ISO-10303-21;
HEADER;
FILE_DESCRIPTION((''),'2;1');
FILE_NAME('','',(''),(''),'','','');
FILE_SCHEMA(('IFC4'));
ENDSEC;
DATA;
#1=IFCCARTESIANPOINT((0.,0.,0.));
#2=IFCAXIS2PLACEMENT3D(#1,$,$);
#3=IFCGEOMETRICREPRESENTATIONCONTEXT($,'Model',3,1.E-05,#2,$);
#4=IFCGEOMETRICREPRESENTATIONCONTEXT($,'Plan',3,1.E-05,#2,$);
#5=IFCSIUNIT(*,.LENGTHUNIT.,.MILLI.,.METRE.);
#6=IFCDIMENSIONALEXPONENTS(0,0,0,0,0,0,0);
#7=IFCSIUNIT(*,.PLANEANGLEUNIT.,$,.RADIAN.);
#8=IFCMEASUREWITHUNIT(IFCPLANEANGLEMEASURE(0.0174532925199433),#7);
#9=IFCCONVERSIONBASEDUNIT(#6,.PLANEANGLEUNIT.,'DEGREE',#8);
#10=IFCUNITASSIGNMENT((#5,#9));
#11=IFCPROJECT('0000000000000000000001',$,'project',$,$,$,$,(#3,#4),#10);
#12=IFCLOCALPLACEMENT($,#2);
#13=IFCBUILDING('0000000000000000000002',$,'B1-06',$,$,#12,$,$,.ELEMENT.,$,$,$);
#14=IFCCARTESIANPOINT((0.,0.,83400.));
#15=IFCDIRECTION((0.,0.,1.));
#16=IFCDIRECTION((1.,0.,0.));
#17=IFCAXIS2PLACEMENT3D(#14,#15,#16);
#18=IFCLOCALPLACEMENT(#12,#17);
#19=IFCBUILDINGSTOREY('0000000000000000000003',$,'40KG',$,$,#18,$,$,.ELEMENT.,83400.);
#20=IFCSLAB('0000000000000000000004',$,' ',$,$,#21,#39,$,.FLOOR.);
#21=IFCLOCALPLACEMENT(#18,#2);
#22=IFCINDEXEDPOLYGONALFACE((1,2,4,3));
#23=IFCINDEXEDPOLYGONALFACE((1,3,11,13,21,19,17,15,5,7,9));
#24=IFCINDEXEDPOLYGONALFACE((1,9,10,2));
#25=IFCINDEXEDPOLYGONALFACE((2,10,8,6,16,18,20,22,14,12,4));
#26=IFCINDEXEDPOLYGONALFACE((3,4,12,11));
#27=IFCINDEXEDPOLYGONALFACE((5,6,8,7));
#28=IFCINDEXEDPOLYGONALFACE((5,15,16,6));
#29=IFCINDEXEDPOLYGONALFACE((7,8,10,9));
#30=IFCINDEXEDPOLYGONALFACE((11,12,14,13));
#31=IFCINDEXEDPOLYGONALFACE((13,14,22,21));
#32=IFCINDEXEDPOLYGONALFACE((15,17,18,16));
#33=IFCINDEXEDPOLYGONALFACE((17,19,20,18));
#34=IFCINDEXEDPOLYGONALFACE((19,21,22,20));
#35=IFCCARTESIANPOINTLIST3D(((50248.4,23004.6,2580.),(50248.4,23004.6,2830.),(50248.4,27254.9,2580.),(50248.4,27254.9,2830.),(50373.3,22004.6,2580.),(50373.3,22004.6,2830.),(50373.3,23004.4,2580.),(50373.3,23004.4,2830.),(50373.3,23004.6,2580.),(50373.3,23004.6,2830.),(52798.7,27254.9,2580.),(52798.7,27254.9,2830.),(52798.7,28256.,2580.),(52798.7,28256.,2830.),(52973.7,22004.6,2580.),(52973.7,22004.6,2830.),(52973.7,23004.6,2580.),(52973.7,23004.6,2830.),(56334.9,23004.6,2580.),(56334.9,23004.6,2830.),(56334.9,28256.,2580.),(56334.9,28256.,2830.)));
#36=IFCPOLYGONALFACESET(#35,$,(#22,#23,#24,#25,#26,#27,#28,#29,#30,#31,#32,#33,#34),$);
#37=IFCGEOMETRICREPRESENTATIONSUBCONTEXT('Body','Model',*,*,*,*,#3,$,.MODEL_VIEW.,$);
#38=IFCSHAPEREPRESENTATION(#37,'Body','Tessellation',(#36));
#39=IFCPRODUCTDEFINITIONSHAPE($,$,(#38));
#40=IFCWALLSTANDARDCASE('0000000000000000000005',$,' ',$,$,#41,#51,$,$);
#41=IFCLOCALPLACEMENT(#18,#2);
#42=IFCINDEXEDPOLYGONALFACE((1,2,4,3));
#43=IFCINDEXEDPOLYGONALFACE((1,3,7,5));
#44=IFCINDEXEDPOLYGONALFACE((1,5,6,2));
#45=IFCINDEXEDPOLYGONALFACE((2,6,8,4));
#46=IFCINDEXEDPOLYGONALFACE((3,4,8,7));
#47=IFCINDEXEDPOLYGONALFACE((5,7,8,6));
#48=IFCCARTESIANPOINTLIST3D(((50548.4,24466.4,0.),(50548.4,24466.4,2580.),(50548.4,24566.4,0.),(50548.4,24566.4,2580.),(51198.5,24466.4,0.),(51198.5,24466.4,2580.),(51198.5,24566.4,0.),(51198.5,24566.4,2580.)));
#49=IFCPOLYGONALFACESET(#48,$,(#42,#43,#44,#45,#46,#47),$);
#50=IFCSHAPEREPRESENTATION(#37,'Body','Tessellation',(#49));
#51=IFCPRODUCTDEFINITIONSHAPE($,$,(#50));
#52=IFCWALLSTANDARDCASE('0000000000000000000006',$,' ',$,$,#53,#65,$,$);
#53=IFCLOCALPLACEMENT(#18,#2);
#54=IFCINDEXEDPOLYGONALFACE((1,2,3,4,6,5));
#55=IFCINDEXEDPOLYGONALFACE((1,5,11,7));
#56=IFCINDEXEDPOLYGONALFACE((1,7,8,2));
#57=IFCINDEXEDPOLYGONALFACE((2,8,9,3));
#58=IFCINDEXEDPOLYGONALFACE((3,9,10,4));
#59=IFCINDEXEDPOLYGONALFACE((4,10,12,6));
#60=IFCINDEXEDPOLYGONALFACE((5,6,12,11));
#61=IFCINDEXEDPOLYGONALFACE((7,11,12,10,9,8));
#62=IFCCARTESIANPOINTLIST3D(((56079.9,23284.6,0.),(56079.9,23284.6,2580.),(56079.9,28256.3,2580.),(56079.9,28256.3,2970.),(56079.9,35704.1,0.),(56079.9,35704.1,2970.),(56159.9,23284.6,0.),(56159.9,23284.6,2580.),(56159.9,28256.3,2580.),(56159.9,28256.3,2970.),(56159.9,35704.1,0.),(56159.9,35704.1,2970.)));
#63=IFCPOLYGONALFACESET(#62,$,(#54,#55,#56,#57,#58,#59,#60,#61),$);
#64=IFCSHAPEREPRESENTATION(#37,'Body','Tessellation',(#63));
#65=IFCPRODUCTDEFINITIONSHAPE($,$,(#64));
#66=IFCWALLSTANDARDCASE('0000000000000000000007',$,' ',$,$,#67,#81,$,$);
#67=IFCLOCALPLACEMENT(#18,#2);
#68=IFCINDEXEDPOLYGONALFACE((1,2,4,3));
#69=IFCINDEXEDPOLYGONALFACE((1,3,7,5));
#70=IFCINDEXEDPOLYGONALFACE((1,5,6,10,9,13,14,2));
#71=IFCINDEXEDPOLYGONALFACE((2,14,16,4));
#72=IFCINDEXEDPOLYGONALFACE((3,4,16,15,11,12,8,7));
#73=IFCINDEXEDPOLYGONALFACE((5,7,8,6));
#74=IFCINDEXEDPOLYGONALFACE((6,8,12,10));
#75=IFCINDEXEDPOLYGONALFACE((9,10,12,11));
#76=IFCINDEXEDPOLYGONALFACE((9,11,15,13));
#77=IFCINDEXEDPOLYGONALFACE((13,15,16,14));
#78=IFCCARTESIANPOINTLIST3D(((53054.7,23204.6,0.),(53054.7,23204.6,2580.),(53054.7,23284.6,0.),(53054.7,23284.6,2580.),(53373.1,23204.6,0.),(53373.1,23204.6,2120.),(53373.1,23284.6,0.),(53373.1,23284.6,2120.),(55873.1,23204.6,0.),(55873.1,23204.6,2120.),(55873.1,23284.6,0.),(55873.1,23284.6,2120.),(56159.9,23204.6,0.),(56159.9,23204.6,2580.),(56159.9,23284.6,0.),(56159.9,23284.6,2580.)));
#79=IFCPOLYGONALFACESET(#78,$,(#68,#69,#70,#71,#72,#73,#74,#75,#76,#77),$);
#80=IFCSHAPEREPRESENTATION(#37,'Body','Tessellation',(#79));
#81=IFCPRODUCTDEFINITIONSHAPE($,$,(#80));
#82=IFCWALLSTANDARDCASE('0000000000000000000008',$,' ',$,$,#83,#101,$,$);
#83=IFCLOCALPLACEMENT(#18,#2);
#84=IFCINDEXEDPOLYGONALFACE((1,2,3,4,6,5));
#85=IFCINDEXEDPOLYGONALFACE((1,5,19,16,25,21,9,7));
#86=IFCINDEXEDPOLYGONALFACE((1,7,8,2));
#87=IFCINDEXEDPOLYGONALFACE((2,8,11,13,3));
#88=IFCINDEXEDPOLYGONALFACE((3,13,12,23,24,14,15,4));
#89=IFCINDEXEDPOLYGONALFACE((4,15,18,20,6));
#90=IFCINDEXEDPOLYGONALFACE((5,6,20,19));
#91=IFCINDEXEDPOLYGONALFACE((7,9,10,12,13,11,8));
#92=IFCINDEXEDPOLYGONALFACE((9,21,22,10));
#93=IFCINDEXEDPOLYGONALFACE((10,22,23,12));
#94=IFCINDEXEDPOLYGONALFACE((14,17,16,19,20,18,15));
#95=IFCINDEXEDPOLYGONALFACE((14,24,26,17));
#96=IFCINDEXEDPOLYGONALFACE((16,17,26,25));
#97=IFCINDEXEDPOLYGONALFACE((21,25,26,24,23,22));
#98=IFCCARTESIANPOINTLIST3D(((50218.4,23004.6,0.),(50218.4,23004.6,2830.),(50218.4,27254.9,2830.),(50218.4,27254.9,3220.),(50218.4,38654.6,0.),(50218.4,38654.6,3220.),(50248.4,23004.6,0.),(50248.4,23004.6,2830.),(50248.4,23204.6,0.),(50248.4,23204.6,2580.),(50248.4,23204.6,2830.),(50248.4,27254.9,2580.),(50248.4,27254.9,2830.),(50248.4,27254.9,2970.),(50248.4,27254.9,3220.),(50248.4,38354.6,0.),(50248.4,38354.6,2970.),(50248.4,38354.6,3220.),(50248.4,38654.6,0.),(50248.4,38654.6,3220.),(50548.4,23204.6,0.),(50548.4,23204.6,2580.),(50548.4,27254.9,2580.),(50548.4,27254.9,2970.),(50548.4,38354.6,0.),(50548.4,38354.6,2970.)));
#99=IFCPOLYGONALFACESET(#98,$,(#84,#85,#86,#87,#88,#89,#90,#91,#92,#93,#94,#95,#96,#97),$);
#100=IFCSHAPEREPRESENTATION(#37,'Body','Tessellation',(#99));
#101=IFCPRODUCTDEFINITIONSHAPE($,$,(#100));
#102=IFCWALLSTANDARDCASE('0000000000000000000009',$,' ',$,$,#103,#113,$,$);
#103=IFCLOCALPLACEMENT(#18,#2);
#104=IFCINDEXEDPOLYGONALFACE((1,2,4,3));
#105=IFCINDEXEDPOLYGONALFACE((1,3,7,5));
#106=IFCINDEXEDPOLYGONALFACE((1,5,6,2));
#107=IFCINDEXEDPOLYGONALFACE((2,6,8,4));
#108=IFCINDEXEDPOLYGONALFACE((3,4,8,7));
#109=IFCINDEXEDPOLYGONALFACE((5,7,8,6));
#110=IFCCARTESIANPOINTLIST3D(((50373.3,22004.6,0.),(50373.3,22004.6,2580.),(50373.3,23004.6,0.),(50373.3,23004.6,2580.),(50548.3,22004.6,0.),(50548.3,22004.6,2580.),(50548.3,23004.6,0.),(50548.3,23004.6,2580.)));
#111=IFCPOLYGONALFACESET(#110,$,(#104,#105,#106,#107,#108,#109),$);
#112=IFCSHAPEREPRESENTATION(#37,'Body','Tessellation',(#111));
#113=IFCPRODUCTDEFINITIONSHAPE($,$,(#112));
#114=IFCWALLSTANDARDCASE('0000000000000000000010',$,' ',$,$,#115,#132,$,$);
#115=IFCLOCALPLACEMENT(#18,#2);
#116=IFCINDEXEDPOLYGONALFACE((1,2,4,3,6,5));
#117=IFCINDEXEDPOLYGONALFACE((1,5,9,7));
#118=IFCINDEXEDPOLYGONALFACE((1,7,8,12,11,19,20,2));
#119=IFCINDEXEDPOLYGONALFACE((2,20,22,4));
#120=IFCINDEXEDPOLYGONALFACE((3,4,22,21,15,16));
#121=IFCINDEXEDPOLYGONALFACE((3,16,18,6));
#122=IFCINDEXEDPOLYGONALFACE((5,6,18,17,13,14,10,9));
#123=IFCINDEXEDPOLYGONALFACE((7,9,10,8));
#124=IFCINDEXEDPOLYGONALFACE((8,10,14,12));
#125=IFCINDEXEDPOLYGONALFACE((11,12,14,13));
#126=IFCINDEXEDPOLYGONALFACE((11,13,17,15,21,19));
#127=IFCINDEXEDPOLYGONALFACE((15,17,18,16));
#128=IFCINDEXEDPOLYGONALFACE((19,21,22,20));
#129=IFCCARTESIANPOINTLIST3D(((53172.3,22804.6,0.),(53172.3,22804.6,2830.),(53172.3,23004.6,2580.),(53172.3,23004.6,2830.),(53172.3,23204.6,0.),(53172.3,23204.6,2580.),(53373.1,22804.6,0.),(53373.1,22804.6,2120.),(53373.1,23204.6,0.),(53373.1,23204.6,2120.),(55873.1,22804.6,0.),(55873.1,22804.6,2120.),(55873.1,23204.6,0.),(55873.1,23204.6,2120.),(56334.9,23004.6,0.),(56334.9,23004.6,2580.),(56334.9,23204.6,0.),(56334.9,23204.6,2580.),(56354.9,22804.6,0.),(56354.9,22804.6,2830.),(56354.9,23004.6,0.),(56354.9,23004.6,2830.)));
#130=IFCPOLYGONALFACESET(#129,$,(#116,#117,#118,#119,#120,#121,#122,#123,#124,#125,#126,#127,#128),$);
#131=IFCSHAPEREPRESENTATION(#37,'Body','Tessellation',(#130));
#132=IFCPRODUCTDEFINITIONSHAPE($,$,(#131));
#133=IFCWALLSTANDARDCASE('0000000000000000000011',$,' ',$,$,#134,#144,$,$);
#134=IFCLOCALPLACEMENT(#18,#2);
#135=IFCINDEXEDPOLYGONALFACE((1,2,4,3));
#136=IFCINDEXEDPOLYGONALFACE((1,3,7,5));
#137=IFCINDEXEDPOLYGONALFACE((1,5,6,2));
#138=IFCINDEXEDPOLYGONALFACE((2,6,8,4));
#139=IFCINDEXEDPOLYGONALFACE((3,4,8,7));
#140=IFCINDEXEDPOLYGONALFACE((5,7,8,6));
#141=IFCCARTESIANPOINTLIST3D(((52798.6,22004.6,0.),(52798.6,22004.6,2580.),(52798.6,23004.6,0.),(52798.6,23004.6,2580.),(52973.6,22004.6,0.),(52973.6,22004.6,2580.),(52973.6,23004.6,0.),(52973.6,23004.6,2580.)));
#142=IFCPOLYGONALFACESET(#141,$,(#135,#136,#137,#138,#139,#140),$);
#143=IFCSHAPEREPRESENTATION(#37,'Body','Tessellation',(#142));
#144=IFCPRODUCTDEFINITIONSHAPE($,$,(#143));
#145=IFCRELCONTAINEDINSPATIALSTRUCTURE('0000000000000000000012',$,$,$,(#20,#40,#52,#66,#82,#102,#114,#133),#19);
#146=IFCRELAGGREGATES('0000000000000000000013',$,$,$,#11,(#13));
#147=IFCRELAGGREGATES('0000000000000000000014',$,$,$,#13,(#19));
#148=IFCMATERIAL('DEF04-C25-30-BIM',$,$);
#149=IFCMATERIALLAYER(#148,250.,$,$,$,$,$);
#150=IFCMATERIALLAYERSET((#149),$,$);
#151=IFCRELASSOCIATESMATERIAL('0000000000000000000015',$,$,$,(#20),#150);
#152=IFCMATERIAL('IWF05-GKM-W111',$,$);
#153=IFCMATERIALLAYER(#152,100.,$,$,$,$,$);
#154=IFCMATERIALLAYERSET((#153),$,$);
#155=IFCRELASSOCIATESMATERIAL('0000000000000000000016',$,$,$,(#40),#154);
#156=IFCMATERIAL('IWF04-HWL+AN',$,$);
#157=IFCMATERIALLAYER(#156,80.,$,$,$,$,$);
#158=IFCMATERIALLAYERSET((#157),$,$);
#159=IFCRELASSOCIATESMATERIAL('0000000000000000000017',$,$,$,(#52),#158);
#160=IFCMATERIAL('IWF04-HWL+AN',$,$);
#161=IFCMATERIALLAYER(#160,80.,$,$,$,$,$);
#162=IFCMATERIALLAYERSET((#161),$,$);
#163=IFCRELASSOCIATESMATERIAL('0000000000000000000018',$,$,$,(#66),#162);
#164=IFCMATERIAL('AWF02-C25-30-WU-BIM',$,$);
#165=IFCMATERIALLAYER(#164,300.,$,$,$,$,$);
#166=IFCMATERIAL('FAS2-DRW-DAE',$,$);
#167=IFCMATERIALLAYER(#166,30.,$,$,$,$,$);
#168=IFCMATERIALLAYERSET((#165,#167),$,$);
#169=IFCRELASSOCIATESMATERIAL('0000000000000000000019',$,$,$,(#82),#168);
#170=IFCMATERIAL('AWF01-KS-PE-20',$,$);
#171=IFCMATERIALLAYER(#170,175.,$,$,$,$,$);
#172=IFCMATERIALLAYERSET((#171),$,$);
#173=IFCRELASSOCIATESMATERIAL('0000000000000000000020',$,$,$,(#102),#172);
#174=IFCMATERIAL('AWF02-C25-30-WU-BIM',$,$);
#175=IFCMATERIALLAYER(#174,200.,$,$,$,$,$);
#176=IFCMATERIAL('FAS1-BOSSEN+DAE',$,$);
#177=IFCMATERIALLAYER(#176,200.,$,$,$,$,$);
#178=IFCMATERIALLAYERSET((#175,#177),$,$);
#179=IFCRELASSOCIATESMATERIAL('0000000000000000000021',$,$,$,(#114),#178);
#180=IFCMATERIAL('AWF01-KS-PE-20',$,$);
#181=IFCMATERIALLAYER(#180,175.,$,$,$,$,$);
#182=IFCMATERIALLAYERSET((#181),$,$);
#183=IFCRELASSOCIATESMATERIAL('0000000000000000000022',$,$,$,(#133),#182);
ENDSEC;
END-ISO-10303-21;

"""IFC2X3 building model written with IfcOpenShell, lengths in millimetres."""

from ifc_helpers import new_model, entity, si_unit, converted_unit, frame, frame_2d, origin, origin_with_axes, place, context, subcontext, project, spatial, polyline, rectangle, outline, extrude, clip, bounded_halfspace, material, layer, layer_set, layer_usage, element, save


model = new_model("IFC2X3")

# Units and contexts
model_context = context("Model", 3, precision=1e-05, world=origin())
plan_context = context("Plan", 3, precision=1e-05, world=origin())
body_context = subcontext(model_context, "Body", "Model", "MODEL_VIEW")
ifc_project = project(units=[si_unit("LENGTHUNIT", "METRE", prefix="MILLI"), converted_unit("PLANEANGLEUNIT", "DEGREE", entity("IfcPlaneAngleMeasure", 0.0174532925199433), si_unit("PLANEANGLEUNIT", "RADIAN"), dimensions=[0, 0, 0, 0, 0, 0, 0])], contexts=[model_context, plan_context])

# Building, storey
building_placement = place(None, origin())
building = spatial("IfcBuilding", under=ifc_project, at=building_placement, Name="B1-06", CompositionType="ELEMENT")
storey_placement = place(building_placement, frame((0.0, 0.0, 83400.0), z_axis=(0.0, 0.0, 1.0), x_axis=(1.0, 0.0, 0.0)))
storey = spatial("IfcBuildingStorey", under=building, at=storey_placement, Name="40KG", CompositionType="ELEMENT", Elevation=83400.0)

# Slab
ifc_material_1 = material(Name="DEF04-C25-30-BIM")
ifc_layer_1 = layer(ifc_material_1, 250.0)
ifc_layer_set_1 = layer_set([ifc_layer_1])
ifc_layer_usage_1 = layer_usage(ifc_layer_set_1, "AXIS3", "POSITIVE", 0.0)
slab_placement = place(storey_placement, frame((50248.4, 22004.6, 2580.0), z_axis=(0.0, 0.0, 1.0), x_axis=(1.0, 0.0, 0.0)))
element("IfcSlab", 1, at=slab_placement, inside=storey, material=ifc_layer_usage_1, Name=" ", PredefinedType="FLOOR", context=body_context, shape_type="SweptSolid", body=[
    extrude(outline(polyline([(2725.3, 0.0), (2725.3, 1000.0), (6086.5, 1000.0), (6086.5, 6251.4), (2550.3, 6251.4), (2550.3, 5250.3), (0.0, 5250.3), (0.0, 1000.0), (125.0, 1000.0), (125.0, 999.8), (124.9, 999.8), (124.9, 0.0), (2725.3, 0.0)])), origin_with_axes(), (0.0, 0.0, 1.0), 250.0),
])

# Walls
ifc_material_2 = material(Name="IWF05-GKM-W111")
ifc_layer_2 = layer(ifc_material_2, 100.0)
ifc_layer_set_2 = layer_set([ifc_layer_2])
ifc_layer_usage_2 = layer_usage(ifc_layer_set_2, "AXIS2", "POSITIVE", 0.0)
wall_1_placement = place(storey_placement, frame((51198.5, 24566.4, 0.0), z_axis=(0.0, 0.0, 1.0), x_axis=(-1.0, 0.0, 0.0)))
element("IfcWallStandardCase", 2, at=wall_1_placement, inside=storey, material=ifc_layer_usage_2, Name=" ", context=body_context, shape_type="SweptSolid", body=[
    extrude(rectangle(XDim=650.1, YDim=100.0, at=frame_2d((325.1, 50.0), x_axis=(1.0, 0.0))), origin_with_axes(), (0.0, 0.0, 1.0), 2580.0),
])
ifc_material_3 = material(Name="IWF04-HWL+AN")
ifc_layer_3 = layer(ifc_material_3, 80.0)
ifc_layer_set_3 = layer_set([ifc_layer_3])
ifc_layer_usage_3 = layer_usage(ifc_layer_set_3, "AXIS2", "POSITIVE", 0.0)
wall_2_placement = place(storey_placement, frame((56159.9, 23284.6, 0.0), z_axis=(0.0, 0.0, 1.0), x_axis=(0.0, 1.0, 0.0)))
element("IfcWallStandardCase", 3, at=wall_2_placement, inside=storey, material=ifc_layer_usage_3, Name=" ", context=body_context, shape_type="Clipping", body=[
    clip(clip(extrude(outline(polyline([(0.0, 0.0), (12419.6, 0.0), (12419.6, 80.0), (0.0, 80.0), (0.0, 0.0)])), origin_with_axes(), (0.0, 0.0, 1.0), 2970.0), bounded_halfspace(frame((0.0, 0.0, 2580.0), z_axis=(0.0, 0.0, -1.0), x_axis=(1.0, 0.0, 0.0)), True, origin(), polyline([(0.0, 0.0), (4971.7, 0.0), (4971.7, 80.0), (0.0, 80.0), (0.0, 0.0)]))), bounded_halfspace(frame((4971.7, 80.0, 2970.0), z_axis=(0.0, 0.0, -1.0), x_axis=(0.0, -1.0, 0.0)), True, origin(), polyline([(4971.7, 80.0), (4971.7, 0.0), (12419.6, 0.0), (12419.6, 80.0), (4971.7, 80.0)]))),
])

# Wall, opening
ifc_material_4 = material(Name="IWF04-HWL+AN")
ifc_layer_4 = layer(ifc_material_4, 80.0)
ifc_layer_set_4 = layer_set([ifc_layer_4])
ifc_layer_usage_4 = layer_usage(ifc_layer_set_4, "AXIS2", "POSITIVE", 0.0)
wall_3_placement = place(storey_placement, frame((53054.7, 23204.6, 0.0), z_axis=(0.0, 0.0, 1.0), x_axis=(1.0, 0.0, 0.0)))
wall_3 = element("IfcWallStandardCase", 4, at=wall_3_placement, inside=storey, material=ifc_layer_usage_4, Name=" ", context=body_context, shape_type="SweptSolid", body=[
    extrude(rectangle(XDim=3105.2, YDim=80.0, at=frame_2d((1552.6, 40.0), x_axis=(1.0, 0.0))), origin_with_axes(), (0.0, 0.0, 1.0), 2580.0),
])
opening_1_placement = place(wall_3_placement, frame((318.4, 0.0, 0.0), z_axis=(0.0, 1.0, 0.0), x_axis=(0.0, 0.0, 1.0)))
element("IfcOpeningElement", 5, at=opening_1_placement, cuts=wall_3, ObjectType="Opening", context=body_context, shape_type="SweptSolid", body=[
    extrude(rectangle(XDim=2120.0, YDim=2500.0, at=frame_2d((1060.0, 1250.0), x_axis=(1.0, 0.0))), origin_with_axes(), (0.0, 0.0, 1.0), 80.0),
])

# Walls
ifc_material_5 = material(Name="AWF02-C25-30-WU-BIM")
ifc_layer_5 = layer(ifc_material_5, 300.0)
ifc_material_6 = material(Name="FAS2-DRW-DAE")
ifc_layer_6 = layer(ifc_material_6, 30.0)
ifc_layer_set_5 = layer_set([ifc_layer_5, ifc_layer_6])
ifc_layer_usage_5 = layer_usage(ifc_layer_set_5, "AXIS2", "POSITIVE", 0.0)
wall_4_placement = place(storey_placement, frame((50548.4, 23204.6, 0.0), z_axis=(0.0, 0.0, 1.0), x_axis=(0.0, 1.0, 0.0)))
element("IfcWallStandardCase", 6, at=wall_4_placement, inside=storey, material=ifc_layer_usage_5, Name=" ", context=body_context, shape_type="Clipping", body=[
    clip(clip(clip(clip(extrude(outline(polyline([(0.0, 0.0), (15150.0, 0.0), (15150.0, 300.0), (15450.0, 300.0), (15450.0, 330.0), (-200.0, 330.0), (-200.0, 300.0), (0.0, 300.0), (0.0, 0.0)])), origin_with_axes(), (0.0, 0.0, 1.0), 3220.0), bounded_halfspace(frame((0.0, 0.0, 2580.0), z_axis=(0.0, 0.0, -1.0), x_axis=(1.0, 0.0, 0.0)), True, origin(), polyline([(0.0, 0.0), (4050.3, 0.0), (4050.3, 300.0), (0.0, 300.0), (0.0, 0.0)]))), bounded_halfspace(frame((4050.3, 300.0, 2970.0), z_axis=(0.0, 0.0, -1.0), x_axis=(0.0, -1.0, 0.0)), True, origin(), polyline([(4050.3, 300.0), (4050.3, 0.0), (15150.0, 0.0), (15150.0, 300.0), (4050.3, 300.0)]))), bounded_halfspace(frame((4050.3, 330.0, 2830.0), z_axis=(0.0, 0.0, -1.0), x_axis=(-1.0, 0.0, 0.0)), True, origin(), polyline([(4050.3, 330.0), (-200.0, 330.0), (-200.0, 300.0), (4050.3, 300.0), (4050.3, 330.0)]))), bounded_halfspace(frame((4050.3, 330.0, 3220.0), z_axis=(0.0, 0.0, -1.0), x_axis=(0.0, -1.0, 0.0)), True, origin(), polyline([(4050.3, 330.0), (4050.3, 300.0), (15450.0, 300.0), (15450.0, 330.0), (4050.3, 330.0)]))),
])
ifc_material_7 = material(Name="AWF01-KS-PE-20")
ifc_layer_7 = layer(ifc_material_7, 175.0)
ifc_layer_set_6 = layer_set([ifc_layer_7])
ifc_layer_usage_6 = layer_usage(ifc_layer_set_6, "AXIS2", "POSITIVE", 0.0)
wall_5_placement = place(storey_placement, frame((50373.3, 23004.6, 0.0), z_axis=(0.0, 0.0, 1.0), x_axis=(0.0, -1.0, 0.0)))
element("IfcWallStandardCase", 7, at=wall_5_placement, inside=storey, material=ifc_layer_usage_6, Name=" ", context=body_context, shape_type="SweptSolid", body=[
    extrude(rectangle(XDim=1000.0, YDim=175.0, at=frame_2d((500.0, 87.5), x_axis=(1.0, 0.0))), origin_with_axes(), (0.0, 0.0, 1.0), 2580.0),
])

# Wall, opening
ifc_material_8 = material(Name="AWF02-C25-30-WU-BIM")
ifc_layer_8 = layer(ifc_material_8, 200.0)
ifc_material_9 = material(Name="FAS1-BOSSEN+DAE")
ifc_layer_9 = layer(ifc_material_9, 200.0)
ifc_layer_set_7 = layer_set([ifc_layer_8, ifc_layer_9])
ifc_layer_usage_7 = layer_usage(ifc_layer_set_7, "AXIS2", "POSITIVE", 0.0)
wall_6_placement = place(storey_placement, frame((56334.9, 23204.6, 0.0), z_axis=(0.0, 0.0, 1.0), x_axis=(-1.0, 0.0, 0.0)))
wall_6 = element("IfcWallStandardCase", 8, at=wall_6_placement, inside=storey, material=ifc_layer_usage_7, Name=" ", context=body_context, shape_type="Clipping", body=[
    clip(clip(extrude(outline(polyline([(-20.0, 400.0), (-20.0, 200.0), (0.0, 200.0), (0.0, 0.0), (3162.6, 0.0), (3162.6, 400.0), (-20.0, 400.0)])), origin_with_axes(), (0.0, 0.0, 1.0), 2830.0), bounded_halfspace(frame((0.0, 0.0, 2580.0), z_axis=(0.0, 0.0, -1.0), x_axis=(1.0, 0.0, 0.0)), True, origin(), polyline([(0.0, 0.0), (3162.6, 0.0), (3162.6, 200.0), (0.0, 200.0), (0.0, 0.0)]))), bounded_halfspace(frame((3162.6, 400.0, 2830.0), z_axis=(0.0, 0.0, -1.0), x_axis=(-1.0, 0.0, 0.0)), True, origin(), polyline([(3162.6, 400.0), (-20.0, 400.0), (-20.0, 200.0), (3162.6, 200.0), (3162.6, 400.0)]))),
])
opening_2_placement = place(wall_6_placement, frame((461.8, 0.0, 0.0), z_axis=(0.0, 1.0, 0.0), x_axis=(0.0, 0.0, 1.0)))
element("IfcOpeningElement", 9, at=opening_2_placement, cuts=wall_6, ObjectType="Opening", context=body_context, shape_type="SweptSolid", body=[
    extrude(rectangle(XDim=2120.0, YDim=2500.0, at=frame_2d((1060.0, 1250.0), x_axis=(1.0, 0.0))), origin_with_axes(), (0.0, 0.0, 1.0), 400.0),
])

# Wall
ifc_material_10 = material(Name="AWF01-KS-PE-20")
ifc_layer_10 = layer(ifc_material_10, 175.0)
ifc_layer_set_8 = layer_set([ifc_layer_10])
ifc_layer_usage_8 = layer_usage(ifc_layer_set_8, "AXIS2", "POSITIVE", 0.0)
wall_7_placement = place(storey_placement, frame((52973.6, 22004.6, 0.0), z_axis=(0.0, 0.0, 1.0), x_axis=(0.0, 1.0, 0.0)))
element("IfcWallStandardCase", 10, at=wall_7_placement, inside=storey, material=ifc_layer_usage_8, Name=" ", context=body_context, shape_type="SweptSolid", body=[
    extrude(rectangle(XDim=1000.0, YDim=175.0, at=frame_2d((500.0, 87.5), x_axis=(1.0, 0.0))), origin_with_axes(), (0.0, 0.0, 1.0), 2580.0),
])

save(model, "model.ifc")
